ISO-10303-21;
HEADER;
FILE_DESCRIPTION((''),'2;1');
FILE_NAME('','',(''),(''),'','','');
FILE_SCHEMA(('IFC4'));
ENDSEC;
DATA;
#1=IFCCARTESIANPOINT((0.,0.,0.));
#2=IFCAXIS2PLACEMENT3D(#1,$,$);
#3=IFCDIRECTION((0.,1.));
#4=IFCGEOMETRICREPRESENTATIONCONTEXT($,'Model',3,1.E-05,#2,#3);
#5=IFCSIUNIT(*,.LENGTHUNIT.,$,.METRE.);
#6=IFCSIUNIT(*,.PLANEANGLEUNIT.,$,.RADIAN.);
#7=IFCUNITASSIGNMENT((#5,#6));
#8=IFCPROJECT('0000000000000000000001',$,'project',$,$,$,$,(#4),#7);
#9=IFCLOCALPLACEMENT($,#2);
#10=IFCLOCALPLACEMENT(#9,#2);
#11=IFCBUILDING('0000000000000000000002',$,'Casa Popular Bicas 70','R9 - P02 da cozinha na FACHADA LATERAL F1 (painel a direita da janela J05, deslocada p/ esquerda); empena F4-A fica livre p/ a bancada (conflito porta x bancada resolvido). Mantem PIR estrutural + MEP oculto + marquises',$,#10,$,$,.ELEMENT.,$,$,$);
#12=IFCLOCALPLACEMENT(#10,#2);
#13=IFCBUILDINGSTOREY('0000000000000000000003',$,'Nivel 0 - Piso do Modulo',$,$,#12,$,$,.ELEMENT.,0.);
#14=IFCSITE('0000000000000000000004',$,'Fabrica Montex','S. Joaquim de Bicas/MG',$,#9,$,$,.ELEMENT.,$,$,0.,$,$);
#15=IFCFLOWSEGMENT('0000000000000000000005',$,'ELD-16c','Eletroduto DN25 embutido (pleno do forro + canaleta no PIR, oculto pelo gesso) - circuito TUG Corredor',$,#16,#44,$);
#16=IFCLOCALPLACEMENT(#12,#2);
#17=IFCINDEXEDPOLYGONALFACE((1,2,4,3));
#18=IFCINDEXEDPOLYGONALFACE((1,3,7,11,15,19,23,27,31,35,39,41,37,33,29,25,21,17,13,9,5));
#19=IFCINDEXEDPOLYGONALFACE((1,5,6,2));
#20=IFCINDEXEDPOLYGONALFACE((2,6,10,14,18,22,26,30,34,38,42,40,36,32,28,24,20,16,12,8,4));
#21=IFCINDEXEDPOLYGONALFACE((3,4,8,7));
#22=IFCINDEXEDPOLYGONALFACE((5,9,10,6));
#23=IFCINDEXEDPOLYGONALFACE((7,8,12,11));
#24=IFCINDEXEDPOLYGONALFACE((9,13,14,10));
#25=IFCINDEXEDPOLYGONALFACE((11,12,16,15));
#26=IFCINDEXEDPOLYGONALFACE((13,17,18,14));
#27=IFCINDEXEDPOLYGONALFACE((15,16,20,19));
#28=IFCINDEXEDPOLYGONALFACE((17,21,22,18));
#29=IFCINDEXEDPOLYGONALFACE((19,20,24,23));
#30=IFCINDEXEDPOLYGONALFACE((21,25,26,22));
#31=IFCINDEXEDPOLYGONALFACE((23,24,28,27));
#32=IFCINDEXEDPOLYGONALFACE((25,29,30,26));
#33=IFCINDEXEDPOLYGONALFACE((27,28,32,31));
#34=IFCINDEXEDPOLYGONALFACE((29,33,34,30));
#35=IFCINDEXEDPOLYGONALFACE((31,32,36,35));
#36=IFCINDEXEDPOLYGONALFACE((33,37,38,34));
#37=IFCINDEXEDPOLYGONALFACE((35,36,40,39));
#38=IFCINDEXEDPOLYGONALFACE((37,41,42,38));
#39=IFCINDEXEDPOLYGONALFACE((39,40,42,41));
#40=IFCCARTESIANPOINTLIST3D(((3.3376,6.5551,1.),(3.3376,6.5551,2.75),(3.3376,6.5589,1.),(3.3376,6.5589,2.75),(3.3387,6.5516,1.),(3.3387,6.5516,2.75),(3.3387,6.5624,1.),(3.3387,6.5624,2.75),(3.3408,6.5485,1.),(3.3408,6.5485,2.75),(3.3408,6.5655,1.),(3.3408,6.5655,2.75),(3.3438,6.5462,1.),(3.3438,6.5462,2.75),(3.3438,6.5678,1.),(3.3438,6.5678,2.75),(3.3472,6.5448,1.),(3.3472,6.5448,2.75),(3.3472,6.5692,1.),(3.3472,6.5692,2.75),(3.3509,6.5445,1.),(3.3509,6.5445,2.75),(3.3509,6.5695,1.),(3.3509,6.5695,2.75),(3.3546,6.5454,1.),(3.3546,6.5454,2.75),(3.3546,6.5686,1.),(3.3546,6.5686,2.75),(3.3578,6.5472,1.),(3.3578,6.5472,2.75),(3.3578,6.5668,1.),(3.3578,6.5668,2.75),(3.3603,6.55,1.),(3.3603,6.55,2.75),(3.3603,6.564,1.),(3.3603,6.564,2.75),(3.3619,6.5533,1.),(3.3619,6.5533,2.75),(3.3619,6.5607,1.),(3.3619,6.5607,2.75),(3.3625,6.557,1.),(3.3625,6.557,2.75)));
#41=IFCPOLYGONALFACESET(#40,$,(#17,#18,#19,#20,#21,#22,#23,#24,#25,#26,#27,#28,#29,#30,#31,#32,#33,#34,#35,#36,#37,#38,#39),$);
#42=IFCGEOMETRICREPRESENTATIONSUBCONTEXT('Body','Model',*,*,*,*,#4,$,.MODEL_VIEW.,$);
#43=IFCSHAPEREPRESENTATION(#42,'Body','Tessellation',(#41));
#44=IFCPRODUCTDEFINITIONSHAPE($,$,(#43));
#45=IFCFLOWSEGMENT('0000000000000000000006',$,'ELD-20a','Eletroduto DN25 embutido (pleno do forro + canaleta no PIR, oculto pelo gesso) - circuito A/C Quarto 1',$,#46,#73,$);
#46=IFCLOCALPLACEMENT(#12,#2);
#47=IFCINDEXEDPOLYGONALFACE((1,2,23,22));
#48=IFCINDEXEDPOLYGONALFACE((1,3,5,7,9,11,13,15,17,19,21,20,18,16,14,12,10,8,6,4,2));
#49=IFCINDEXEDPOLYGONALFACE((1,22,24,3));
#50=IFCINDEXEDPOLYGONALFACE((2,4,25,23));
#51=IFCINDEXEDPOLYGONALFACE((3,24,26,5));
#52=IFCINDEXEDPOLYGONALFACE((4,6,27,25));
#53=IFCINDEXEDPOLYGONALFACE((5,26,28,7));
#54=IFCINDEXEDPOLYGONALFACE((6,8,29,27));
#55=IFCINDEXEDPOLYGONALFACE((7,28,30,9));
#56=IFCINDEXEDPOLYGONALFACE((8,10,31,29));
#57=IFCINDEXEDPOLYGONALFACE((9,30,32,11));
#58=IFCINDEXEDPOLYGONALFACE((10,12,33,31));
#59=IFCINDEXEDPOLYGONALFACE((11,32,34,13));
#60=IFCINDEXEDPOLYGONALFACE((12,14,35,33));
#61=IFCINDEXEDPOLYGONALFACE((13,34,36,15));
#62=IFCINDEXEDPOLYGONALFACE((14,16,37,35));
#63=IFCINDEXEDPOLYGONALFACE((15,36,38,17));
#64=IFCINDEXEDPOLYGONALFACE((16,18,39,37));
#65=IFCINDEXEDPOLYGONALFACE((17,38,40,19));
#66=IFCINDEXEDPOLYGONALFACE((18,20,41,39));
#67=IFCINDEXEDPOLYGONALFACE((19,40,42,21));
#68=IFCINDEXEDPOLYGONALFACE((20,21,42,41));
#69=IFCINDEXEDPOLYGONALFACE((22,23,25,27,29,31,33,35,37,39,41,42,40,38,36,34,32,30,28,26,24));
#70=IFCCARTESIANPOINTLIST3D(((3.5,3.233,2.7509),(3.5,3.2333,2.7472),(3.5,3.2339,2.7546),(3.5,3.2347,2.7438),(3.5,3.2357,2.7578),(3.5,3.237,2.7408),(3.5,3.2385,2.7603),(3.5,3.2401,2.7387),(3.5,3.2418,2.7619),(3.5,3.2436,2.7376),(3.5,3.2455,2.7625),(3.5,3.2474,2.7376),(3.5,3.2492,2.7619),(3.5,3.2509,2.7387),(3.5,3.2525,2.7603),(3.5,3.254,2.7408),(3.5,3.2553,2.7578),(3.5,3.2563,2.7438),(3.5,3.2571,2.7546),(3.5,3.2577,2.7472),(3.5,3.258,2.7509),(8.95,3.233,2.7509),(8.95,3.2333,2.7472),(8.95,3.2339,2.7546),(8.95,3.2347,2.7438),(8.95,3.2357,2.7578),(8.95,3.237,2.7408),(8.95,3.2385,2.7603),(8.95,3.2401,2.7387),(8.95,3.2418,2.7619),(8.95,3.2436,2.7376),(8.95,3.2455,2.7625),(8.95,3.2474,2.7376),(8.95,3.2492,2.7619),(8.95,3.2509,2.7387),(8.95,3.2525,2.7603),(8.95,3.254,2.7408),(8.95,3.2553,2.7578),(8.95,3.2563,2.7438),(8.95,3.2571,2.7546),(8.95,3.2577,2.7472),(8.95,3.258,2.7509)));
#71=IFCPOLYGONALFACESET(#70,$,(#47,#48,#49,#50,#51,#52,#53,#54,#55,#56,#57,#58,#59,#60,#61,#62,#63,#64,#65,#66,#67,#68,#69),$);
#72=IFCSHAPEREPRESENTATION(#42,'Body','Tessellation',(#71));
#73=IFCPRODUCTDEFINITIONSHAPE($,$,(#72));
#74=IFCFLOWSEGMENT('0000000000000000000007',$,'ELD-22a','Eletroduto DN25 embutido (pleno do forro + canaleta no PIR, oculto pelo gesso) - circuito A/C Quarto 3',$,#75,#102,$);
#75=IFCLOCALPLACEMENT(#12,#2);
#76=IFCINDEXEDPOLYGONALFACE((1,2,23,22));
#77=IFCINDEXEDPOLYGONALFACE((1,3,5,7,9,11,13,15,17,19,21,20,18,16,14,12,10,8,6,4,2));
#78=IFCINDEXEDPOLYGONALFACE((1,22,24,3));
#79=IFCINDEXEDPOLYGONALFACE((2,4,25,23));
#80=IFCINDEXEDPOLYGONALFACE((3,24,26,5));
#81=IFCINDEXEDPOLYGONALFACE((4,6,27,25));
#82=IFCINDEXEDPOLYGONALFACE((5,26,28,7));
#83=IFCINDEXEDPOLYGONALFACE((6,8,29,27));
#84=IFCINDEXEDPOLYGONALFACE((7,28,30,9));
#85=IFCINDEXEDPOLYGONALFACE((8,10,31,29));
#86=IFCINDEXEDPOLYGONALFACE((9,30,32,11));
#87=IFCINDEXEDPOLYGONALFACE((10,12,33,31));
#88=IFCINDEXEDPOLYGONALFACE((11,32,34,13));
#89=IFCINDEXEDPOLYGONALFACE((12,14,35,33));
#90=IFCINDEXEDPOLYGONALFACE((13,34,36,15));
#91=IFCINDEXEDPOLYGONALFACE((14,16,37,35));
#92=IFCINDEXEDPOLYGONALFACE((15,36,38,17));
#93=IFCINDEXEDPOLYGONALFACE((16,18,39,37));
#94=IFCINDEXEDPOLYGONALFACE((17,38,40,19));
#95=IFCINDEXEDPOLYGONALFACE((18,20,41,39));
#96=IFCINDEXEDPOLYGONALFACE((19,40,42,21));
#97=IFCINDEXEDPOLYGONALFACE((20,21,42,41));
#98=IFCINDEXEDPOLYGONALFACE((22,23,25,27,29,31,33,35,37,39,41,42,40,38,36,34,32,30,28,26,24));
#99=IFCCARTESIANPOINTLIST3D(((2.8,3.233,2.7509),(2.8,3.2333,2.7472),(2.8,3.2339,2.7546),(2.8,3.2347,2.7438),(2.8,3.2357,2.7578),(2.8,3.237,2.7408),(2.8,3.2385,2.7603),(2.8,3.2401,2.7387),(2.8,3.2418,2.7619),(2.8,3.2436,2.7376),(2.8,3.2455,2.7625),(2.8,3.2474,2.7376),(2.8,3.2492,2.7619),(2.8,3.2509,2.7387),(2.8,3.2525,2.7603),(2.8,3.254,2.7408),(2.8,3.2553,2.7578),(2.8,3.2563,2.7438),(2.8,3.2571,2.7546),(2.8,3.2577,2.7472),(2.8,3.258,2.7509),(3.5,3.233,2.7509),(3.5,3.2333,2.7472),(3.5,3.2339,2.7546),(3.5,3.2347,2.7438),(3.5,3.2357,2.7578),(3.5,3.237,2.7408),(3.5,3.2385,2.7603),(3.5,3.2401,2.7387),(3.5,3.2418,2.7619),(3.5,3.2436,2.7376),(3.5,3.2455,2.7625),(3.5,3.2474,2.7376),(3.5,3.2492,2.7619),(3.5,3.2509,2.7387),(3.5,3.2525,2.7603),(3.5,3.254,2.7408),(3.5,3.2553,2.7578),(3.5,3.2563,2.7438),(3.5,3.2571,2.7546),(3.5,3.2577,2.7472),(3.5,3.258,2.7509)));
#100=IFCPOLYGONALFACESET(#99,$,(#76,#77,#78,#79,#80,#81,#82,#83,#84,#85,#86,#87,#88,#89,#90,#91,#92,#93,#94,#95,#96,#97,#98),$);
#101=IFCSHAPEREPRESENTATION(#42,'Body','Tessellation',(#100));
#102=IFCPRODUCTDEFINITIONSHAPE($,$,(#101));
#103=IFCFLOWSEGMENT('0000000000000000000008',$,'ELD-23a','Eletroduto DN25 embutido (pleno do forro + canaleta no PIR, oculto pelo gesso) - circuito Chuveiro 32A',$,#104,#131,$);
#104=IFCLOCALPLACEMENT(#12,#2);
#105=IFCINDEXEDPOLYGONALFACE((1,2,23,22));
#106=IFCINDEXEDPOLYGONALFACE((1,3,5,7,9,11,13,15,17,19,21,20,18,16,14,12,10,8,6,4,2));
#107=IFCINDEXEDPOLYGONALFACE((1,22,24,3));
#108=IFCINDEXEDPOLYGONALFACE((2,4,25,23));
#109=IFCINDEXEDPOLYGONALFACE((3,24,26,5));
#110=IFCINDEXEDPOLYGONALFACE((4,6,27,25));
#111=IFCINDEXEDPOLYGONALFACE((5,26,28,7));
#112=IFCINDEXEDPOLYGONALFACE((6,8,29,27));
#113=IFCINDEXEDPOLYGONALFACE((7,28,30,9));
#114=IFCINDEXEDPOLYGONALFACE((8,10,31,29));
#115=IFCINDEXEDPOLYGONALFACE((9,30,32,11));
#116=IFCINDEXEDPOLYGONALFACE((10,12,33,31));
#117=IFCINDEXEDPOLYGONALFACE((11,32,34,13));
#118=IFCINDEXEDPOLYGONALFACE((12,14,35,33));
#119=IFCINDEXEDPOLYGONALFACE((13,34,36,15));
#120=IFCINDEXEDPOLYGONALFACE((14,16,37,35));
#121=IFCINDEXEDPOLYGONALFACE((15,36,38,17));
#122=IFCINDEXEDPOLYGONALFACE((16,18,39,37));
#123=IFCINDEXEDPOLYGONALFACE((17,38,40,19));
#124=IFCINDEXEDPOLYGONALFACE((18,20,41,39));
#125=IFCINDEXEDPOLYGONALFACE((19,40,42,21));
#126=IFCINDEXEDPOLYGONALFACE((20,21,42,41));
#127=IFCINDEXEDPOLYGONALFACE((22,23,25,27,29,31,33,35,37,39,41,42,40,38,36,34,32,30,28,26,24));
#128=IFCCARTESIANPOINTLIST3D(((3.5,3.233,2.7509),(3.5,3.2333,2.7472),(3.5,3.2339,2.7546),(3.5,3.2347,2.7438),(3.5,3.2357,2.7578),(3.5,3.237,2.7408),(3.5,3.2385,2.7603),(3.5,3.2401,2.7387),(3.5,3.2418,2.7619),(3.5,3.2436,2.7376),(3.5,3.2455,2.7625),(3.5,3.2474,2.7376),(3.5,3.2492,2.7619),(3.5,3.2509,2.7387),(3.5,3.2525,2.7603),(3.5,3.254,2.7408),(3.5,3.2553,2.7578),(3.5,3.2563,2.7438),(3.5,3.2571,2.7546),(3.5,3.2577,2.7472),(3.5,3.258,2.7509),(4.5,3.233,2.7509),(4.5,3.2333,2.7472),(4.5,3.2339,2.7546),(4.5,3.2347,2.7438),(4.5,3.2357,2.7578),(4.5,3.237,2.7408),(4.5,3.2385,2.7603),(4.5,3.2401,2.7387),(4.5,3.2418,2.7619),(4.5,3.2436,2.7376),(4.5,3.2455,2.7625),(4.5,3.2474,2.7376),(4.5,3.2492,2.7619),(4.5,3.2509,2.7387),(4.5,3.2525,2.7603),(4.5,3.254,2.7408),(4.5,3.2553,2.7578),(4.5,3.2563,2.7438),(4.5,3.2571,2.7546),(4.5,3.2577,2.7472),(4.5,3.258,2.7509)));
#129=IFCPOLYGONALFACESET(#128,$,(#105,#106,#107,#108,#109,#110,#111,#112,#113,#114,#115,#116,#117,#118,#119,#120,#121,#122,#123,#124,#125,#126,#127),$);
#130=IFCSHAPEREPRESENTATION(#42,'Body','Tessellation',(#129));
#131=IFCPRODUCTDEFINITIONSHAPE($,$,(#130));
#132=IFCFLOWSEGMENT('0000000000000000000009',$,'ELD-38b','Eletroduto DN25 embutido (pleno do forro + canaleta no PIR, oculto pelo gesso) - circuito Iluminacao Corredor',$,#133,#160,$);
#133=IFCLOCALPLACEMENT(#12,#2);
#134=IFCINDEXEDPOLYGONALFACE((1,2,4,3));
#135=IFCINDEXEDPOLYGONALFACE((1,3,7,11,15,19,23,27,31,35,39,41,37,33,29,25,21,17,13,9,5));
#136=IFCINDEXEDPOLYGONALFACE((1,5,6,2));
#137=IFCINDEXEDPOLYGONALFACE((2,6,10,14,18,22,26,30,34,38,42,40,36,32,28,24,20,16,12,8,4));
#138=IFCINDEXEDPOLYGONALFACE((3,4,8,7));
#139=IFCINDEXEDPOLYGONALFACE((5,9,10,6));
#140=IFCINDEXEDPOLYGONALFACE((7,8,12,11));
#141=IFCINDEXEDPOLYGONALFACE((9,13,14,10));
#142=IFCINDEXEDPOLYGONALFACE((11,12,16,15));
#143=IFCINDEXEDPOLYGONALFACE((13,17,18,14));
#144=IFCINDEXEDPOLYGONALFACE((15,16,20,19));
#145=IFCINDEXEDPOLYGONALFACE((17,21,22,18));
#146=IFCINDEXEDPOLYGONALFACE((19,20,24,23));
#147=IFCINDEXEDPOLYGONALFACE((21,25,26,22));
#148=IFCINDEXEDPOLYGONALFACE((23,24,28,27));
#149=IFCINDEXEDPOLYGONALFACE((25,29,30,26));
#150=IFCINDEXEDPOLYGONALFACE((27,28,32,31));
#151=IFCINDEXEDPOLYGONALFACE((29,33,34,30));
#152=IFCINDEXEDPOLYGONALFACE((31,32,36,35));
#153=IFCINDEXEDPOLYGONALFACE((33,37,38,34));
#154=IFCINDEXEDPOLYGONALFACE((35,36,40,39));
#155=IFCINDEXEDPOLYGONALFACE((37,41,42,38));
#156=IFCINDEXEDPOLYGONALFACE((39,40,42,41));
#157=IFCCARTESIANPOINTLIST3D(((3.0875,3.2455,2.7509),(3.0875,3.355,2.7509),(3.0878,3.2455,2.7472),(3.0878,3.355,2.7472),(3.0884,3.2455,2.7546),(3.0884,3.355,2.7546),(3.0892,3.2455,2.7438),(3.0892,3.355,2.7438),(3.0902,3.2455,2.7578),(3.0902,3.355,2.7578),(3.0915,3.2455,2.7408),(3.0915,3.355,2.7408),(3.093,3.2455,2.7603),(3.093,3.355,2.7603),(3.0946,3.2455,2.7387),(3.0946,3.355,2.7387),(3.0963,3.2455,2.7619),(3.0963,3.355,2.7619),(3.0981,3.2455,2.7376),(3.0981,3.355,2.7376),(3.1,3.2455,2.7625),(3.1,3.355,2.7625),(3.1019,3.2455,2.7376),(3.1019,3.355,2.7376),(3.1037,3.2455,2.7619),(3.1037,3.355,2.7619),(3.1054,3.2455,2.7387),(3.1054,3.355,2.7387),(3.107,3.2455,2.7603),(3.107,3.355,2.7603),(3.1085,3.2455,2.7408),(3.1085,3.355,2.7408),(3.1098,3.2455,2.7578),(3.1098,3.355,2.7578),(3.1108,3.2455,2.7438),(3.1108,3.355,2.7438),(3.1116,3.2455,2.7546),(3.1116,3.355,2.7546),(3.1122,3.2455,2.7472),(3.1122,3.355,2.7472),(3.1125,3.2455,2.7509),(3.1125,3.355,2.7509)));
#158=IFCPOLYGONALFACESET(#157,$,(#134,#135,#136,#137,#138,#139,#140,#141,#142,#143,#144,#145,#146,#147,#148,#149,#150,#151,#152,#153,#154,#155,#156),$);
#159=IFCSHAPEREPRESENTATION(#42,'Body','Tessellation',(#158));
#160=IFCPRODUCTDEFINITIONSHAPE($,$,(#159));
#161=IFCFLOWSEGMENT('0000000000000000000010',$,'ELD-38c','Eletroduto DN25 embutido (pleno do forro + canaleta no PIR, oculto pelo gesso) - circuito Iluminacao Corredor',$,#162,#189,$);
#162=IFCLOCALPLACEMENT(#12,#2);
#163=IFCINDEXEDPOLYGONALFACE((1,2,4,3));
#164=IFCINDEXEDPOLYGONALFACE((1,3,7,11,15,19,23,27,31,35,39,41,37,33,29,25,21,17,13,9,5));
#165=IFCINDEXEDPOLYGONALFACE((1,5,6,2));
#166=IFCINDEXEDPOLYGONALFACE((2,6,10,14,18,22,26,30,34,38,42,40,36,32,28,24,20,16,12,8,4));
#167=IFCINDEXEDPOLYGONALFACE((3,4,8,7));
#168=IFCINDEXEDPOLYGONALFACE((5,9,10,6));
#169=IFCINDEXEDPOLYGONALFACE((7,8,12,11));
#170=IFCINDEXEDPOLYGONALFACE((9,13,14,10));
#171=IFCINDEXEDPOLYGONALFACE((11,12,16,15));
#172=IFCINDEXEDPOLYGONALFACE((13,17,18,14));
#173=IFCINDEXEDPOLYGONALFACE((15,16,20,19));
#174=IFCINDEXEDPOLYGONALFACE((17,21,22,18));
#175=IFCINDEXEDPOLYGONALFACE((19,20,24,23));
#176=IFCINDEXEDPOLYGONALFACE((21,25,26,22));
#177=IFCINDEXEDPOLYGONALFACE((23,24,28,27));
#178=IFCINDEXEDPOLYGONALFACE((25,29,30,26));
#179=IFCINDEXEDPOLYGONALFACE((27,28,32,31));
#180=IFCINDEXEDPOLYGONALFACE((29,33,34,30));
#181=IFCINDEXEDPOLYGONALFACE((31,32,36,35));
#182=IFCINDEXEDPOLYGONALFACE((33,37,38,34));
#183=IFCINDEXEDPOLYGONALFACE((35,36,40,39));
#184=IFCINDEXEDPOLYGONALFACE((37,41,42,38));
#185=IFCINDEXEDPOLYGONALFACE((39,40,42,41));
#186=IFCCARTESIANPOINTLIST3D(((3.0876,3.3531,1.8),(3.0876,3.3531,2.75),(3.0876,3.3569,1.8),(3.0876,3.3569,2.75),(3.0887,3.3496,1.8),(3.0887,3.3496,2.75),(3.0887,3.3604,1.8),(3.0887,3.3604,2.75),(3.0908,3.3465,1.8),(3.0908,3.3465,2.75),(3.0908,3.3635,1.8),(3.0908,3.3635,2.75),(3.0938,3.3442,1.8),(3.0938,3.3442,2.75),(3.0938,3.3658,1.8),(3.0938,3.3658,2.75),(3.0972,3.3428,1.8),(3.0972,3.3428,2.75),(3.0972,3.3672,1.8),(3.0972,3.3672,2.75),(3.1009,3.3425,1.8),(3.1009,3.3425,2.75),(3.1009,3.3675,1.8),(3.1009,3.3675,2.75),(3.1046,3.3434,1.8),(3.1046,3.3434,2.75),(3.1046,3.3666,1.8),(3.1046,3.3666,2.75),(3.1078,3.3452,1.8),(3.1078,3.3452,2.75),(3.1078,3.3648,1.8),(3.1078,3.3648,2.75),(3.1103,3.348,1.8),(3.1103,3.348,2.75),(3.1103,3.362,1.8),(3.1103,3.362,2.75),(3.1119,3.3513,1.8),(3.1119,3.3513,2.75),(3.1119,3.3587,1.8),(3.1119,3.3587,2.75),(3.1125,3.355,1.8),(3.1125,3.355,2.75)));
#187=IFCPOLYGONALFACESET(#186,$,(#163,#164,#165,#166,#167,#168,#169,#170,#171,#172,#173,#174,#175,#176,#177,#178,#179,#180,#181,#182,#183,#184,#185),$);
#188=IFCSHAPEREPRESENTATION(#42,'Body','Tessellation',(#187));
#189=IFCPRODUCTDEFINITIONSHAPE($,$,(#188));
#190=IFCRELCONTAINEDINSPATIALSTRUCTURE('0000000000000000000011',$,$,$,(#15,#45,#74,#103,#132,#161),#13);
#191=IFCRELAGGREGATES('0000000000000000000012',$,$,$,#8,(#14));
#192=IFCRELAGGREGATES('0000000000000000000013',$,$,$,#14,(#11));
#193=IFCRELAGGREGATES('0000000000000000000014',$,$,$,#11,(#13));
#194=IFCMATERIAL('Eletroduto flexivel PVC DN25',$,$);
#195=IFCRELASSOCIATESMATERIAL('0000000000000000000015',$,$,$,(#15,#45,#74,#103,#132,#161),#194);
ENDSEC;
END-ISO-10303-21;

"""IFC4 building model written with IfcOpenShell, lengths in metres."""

from ifc_helpers import new_model, si_unit, direction, frame, origin, origin_2d, place, context, subcontext, project, spatial, circle, extrude, material, element, save


model = new_model("IFC4")

# Units and contexts
model_context = context("Model", 3, precision=1e-05, world=origin(), true_north=direction((0.0, 1.0)))
body_context = subcontext(model_context, "Body", "Model", "MODEL_VIEW")
ifc_project = project(units=[si_unit("LENGTHUNIT", "METRE"), si_unit("PLANEANGLEUNIT", "RADIAN")], contexts=[model_context])

# Site, building, storey
site_placement = place(None, origin())
site = spatial("IfcSite", under=ifc_project, at=site_placement, Name="Fabrica Montex", Description="S. Joaquim de Bicas/MG", CompositionType="ELEMENT", RefElevation=0.0)
building_placement = place(site_placement, origin())
building = spatial("IfcBuilding", under=site, at=building_placement, Name="Casa Popular Bicas 70", Description="R9 - P02 da cozinha na FACHADA LATERAL F1 (painel a direita da janela J05, deslocada p/ esquerda); empena F4-A fica livre p/ a bancada (conflito porta x bancada resolvido). Mantem PIR estrutural + MEP oculto + marquises", CompositionType="ELEMENT")
storey_placement = place(building_placement, origin())
storey = spatial("IfcBuildingStorey", under=building, at=storey_placement, Name="Nivel 0 - Piso do Modulo", CompositionType="ELEMENT", Elevation=0.0)

# Flow segments
ifc_material_1 = material(Name="Eletroduto flexivel PVC DN25")
flow_segment_1_placement = place(storey_placement, frame((3.35, 6.557, 2.75), z_axis=(0.0, 0.0, -1.0), x_axis=(1.0, 0.0, 0.0)))
element("IfcFlowSegment", 1, at=flow_segment_1_placement, inside=storey, material=ifc_material_1, Name="ELD-16c", Description="Eletroduto DN25 embutido (pleno do forro + canaleta no PIR, oculto pelo gesso) - circuito TUG Corredor", context=body_context, shape_type="SweptSolid", body=[
    extrude(circle(Radius=0.0125, at=origin_2d()), origin(), (0.0, 0.0, 1.0), 1.75),
])
flow_segment_2_placement = place(storey_placement, frame((3.5, 3.2455, 2.75), z_axis=(1.0, 0.0, 0.0), x_axis=(0.0, 0.0, 1.0)))
element("IfcFlowSegment", 2, at=flow_segment_2_placement, inside=storey, material=ifc_material_1, Name="ELD-20a", Description="Eletroduto DN25 embutido (pleno do forro + canaleta no PIR, oculto pelo gesso) - circuito A/C Quarto 1", context=body_context, shape_type="SweptSolid", body=[
    extrude(circle(Radius=0.0125, at=origin_2d()), origin(), (0.0, 0.0, 1.0), 5.45),
])
flow_segment_3_placement = place(storey_placement, frame((3.5, 3.2455, 2.75), z_axis=(-1.0, 0.0, 0.0), x_axis=(0.0, 0.0, 1.0)))
element("IfcFlowSegment", 3, at=flow_segment_3_placement, inside=storey, material=ifc_material_1, Name="ELD-22a", Description="Eletroduto DN25 embutido (pleno do forro + canaleta no PIR, oculto pelo gesso) - circuito A/C Quarto 3", context=body_context, shape_type="SweptSolid", body=[
    extrude(circle(Radius=0.0125, at=origin_2d()), origin(), (0.0, 0.0, 1.0), 0.7),
])
flow_segment_4_placement = place(storey_placement, frame((3.5, 3.2455, 2.75), z_axis=(1.0, 0.0, 0.0), x_axis=(0.0, 0.0, 1.0)))
element("IfcFlowSegment", 4, at=flow_segment_4_placement, inside=storey, material=ifc_material_1, Name="ELD-23a", Description="Eletroduto DN25 embutido (pleno do forro + canaleta no PIR, oculto pelo gesso) - circuito Chuveiro 32A", context=body_context, shape_type="SweptSolid", body=[
    extrude(circle(Radius=0.0125, at=origin_2d()), origin(), (0.0, 0.0, 1.0), 1.0),
])
flow_segment_5_placement = place(storey_placement, frame((3.1, 3.2455, 2.75), z_axis=(0.0, 1.0, 0.0), x_axis=(0.0, 0.0, 1.0)))
element("IfcFlowSegment", 5, at=flow_segment_5_placement, inside=storey, material=ifc_material_1, Name="ELD-38b", Description="Eletroduto DN25 embutido (pleno do forro + canaleta no PIR, oculto pelo gesso) - circuito Iluminacao Corredor", context=body_context, shape_type="SweptSolid", body=[
    extrude(circle(Radius=0.0125, at=origin_2d()), origin(), (0.0, 0.0, 1.0), 0.1095),
])
flow_segment_6_placement = place(storey_placement, frame((3.1, 3.355, 2.75), z_axis=(0.0, 0.0, -1.0), x_axis=(1.0, 0.0, 0.0)))
element("IfcFlowSegment", 6, at=flow_segment_6_placement, inside=storey, material=ifc_material_1, Name="ELD-38c", Description="Eletroduto DN25 embutido (pleno do forro + canaleta no PIR, oculto pelo gesso) - circuito Iluminacao Corredor", context=body_context, shape_type="SweptSolid", body=[
    extrude(circle(Radius=0.0125, at=origin_2d()), origin(), (0.0, 0.0, 1.0), 0.95),
])

save(model, "model.ifc")
